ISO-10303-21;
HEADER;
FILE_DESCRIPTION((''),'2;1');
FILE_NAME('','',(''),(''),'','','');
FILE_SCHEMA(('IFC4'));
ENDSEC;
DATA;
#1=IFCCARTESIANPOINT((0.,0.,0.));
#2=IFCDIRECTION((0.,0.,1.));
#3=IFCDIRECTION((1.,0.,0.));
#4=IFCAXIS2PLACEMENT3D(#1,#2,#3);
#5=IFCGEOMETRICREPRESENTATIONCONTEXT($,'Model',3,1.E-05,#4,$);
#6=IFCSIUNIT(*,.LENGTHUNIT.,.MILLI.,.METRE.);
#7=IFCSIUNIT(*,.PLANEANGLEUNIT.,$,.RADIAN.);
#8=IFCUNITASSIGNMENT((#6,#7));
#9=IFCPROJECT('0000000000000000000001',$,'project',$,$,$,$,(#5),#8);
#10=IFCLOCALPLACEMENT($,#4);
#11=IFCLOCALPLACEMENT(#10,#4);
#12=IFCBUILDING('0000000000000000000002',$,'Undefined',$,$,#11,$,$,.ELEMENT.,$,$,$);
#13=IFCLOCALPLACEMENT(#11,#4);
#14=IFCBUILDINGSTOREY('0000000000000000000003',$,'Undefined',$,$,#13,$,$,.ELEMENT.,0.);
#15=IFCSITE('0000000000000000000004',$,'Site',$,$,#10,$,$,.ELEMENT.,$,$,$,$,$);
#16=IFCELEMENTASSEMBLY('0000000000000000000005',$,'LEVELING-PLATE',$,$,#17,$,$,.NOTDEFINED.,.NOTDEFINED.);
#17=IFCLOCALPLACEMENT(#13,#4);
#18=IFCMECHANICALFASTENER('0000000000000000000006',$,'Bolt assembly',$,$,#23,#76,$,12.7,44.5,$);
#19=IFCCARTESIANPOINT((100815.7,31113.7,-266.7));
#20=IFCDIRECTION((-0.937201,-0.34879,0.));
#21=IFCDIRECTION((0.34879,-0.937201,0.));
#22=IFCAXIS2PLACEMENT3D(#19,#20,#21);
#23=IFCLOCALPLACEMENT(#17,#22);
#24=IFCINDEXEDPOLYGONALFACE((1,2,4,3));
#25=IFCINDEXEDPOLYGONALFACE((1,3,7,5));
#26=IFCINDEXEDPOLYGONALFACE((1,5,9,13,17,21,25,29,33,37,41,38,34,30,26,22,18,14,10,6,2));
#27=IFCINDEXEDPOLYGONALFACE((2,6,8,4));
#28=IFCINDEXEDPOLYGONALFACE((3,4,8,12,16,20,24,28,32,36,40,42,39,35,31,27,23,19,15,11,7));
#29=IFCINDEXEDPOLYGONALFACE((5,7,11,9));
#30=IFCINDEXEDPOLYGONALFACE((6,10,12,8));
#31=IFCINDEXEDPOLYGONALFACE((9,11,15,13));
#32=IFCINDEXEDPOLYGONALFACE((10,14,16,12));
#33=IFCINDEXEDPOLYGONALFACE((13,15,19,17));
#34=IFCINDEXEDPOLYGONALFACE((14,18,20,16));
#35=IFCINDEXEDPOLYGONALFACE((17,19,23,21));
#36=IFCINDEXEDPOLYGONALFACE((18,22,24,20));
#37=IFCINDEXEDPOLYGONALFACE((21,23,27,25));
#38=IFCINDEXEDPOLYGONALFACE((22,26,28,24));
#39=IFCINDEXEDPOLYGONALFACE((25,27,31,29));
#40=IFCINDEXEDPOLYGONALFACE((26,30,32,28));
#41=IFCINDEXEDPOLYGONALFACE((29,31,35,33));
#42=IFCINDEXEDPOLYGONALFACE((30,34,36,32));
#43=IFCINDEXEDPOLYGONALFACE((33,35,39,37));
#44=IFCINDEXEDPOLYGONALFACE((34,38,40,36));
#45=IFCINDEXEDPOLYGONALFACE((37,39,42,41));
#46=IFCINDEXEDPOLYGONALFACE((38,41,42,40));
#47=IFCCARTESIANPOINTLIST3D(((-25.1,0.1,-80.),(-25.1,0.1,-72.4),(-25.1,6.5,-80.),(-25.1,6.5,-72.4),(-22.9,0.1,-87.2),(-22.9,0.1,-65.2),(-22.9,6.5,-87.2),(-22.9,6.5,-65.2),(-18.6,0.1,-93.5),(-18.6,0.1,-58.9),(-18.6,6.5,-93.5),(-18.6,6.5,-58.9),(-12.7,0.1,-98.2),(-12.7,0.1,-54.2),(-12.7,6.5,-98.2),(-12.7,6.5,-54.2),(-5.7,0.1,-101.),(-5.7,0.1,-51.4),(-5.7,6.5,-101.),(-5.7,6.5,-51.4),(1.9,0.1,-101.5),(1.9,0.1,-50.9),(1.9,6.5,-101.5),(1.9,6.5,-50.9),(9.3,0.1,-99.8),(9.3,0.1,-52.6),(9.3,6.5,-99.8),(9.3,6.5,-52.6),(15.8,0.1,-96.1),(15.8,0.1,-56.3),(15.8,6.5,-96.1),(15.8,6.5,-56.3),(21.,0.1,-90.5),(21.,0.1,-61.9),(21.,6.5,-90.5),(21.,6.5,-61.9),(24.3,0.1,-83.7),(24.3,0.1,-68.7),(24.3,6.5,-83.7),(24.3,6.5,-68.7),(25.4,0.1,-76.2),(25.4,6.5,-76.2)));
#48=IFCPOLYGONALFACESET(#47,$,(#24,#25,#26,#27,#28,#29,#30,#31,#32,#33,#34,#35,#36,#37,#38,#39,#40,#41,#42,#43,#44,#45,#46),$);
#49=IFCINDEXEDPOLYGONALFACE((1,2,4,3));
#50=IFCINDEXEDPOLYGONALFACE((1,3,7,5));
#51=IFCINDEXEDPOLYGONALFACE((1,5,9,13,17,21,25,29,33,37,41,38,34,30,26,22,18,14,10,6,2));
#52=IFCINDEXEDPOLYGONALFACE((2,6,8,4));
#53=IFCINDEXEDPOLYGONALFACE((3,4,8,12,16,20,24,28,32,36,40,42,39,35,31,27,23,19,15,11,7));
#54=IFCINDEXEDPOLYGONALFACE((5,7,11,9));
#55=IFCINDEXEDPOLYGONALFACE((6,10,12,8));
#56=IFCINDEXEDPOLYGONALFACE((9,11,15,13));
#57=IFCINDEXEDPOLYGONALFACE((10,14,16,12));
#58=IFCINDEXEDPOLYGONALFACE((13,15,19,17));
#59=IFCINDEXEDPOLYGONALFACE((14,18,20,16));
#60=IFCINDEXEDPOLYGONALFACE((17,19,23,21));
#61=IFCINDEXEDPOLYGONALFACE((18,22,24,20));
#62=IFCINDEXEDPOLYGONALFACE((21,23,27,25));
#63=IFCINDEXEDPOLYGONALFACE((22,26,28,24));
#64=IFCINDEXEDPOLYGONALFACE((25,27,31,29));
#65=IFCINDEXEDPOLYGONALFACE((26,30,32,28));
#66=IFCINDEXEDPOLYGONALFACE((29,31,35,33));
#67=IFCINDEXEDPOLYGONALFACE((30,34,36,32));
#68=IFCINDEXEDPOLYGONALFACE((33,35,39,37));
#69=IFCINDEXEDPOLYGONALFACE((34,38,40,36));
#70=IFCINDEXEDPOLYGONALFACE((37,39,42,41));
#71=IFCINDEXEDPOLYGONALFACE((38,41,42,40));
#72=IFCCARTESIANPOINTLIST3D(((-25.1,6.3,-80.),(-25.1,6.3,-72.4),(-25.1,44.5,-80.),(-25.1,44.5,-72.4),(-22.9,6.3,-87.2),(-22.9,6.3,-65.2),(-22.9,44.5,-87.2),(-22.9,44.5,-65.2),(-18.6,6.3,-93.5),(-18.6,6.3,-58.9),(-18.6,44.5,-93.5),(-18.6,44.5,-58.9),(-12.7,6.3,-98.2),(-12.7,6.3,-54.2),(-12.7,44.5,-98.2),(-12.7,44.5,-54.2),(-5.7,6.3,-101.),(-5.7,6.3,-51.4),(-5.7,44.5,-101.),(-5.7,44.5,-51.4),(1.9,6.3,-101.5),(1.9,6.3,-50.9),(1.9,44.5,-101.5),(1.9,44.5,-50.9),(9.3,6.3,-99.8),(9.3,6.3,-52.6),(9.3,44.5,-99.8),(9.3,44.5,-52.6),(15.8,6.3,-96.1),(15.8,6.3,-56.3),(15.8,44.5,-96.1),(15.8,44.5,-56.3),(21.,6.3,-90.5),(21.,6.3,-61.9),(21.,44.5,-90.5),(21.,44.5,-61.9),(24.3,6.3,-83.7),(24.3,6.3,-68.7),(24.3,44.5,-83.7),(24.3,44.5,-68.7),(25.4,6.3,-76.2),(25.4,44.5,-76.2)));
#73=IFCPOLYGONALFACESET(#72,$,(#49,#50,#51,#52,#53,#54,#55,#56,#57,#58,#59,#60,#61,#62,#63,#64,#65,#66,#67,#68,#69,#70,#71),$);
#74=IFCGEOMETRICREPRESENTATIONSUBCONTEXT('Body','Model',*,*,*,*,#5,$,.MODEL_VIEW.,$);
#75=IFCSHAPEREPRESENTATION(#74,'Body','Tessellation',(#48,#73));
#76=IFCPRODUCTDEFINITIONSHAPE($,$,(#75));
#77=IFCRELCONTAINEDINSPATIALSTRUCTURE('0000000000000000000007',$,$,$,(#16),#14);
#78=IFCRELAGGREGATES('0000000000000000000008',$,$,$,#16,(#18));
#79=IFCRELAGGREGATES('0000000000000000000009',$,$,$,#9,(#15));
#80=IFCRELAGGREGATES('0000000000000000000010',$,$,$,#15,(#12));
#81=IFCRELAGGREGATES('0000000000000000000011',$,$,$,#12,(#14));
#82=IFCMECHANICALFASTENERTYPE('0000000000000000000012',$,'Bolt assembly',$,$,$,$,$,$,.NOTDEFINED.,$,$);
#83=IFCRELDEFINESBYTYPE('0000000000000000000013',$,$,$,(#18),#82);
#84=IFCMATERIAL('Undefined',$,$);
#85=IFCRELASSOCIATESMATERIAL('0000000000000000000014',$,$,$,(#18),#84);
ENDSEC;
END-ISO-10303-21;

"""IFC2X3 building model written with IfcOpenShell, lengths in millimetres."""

from ifc_helpers import new_model, si_unit, frame, origin_with_axes, origin_2d_with_axis, place, context, subcontext, project, spatial, circle, extrude, source, transform, mapped, material, type_object, element, aggregate, save


model = new_model("IFC2X3")

# Units and contexts
model_context = context("Model", 3, precision=1e-05, world=origin_with_axes())
body_context = subcontext(model_context, "Body", "Model", "MODEL_VIEW")
ifc_project = project(units=[si_unit("LENGTHUNIT", "METRE", prefix="MILLI"), si_unit("PLANEANGLEUNIT", "RADIAN")], contexts=[model_context])

# Site, building, storey
site_placement = place(None, origin_with_axes())
site = spatial("IfcSite", under=ifc_project, at=site_placement, Name="Site", CompositionType="ELEMENT")
building_placement = place(site_placement, origin_with_axes())
building = spatial("IfcBuilding", under=site, at=building_placement, Name="Undefined", CompositionType="ELEMENT")
storey_placement = place(building_placement, origin_with_axes())
storey = spatial("IfcBuildingStorey", under=building, at=storey_placement, Name="Undefined", CompositionType="ELEMENT", Elevation=0.0)

# Element assembly, mechanical fastener
assembly_1_placement = place(storey_placement, origin_with_axes())
assembly_1 = element("IfcElementAssembly", 1, at=assembly_1_placement, inside=storey, Name="LEVELING-PLATE", AssemblyPlace="NOTDEFINED", PredefinedType="NOTDEFINED")
ifc_material_1 = material(Name="Undefined")
mechanical_fastener_type = type_object("IfcMechanicalFastenerType", Name="Bolt assembly")
shared_shape = source(origin_with_axes(), body_context, "Body", "SweptSolid", [
    extrude(circle(Radius=25.4, at=origin_2d_with_axis()), frame((0.0, 0.1, 0.0), z_axis=(0.0, 1.0, 0.0), x_axis=(1.0, 0.0, 0.0)), (0.0, 0.0, 1.0), 6.3),
    extrude(circle(Radius=25.4, at=origin_2d_with_axis()), frame((0.0, 6.3, 0.0), z_axis=(0.0, 1.0, 0.0), x_axis=(1.0, 0.0, 0.0)), (0.0, 0.0, 1.0), 38.2),
])
mechanical_fastener_placement = place(assembly_1_placement, frame((100815.7, 31113.7, -266.7), z_axis=(-0.937201, -0.34879, 0.0), x_axis=(0.34879, -0.937201, 0.0)))
mechanical_fastener = element("IfcMechanicalFastener", 2, at=mechanical_fastener_placement, type_object=mechanical_fastener_type, material=ifc_material_1, Name="Bolt assembly", NominalDiameter=12.7, NominalLength=44.5, context=body_context, shape_type="MappedRepresentation", body=[
    mapped(shared_shape, transform((0.0, 0.0, -76.2))),
])
aggregate(assembly_1, [mechanical_fastener])

save(model, "model.ifc")
